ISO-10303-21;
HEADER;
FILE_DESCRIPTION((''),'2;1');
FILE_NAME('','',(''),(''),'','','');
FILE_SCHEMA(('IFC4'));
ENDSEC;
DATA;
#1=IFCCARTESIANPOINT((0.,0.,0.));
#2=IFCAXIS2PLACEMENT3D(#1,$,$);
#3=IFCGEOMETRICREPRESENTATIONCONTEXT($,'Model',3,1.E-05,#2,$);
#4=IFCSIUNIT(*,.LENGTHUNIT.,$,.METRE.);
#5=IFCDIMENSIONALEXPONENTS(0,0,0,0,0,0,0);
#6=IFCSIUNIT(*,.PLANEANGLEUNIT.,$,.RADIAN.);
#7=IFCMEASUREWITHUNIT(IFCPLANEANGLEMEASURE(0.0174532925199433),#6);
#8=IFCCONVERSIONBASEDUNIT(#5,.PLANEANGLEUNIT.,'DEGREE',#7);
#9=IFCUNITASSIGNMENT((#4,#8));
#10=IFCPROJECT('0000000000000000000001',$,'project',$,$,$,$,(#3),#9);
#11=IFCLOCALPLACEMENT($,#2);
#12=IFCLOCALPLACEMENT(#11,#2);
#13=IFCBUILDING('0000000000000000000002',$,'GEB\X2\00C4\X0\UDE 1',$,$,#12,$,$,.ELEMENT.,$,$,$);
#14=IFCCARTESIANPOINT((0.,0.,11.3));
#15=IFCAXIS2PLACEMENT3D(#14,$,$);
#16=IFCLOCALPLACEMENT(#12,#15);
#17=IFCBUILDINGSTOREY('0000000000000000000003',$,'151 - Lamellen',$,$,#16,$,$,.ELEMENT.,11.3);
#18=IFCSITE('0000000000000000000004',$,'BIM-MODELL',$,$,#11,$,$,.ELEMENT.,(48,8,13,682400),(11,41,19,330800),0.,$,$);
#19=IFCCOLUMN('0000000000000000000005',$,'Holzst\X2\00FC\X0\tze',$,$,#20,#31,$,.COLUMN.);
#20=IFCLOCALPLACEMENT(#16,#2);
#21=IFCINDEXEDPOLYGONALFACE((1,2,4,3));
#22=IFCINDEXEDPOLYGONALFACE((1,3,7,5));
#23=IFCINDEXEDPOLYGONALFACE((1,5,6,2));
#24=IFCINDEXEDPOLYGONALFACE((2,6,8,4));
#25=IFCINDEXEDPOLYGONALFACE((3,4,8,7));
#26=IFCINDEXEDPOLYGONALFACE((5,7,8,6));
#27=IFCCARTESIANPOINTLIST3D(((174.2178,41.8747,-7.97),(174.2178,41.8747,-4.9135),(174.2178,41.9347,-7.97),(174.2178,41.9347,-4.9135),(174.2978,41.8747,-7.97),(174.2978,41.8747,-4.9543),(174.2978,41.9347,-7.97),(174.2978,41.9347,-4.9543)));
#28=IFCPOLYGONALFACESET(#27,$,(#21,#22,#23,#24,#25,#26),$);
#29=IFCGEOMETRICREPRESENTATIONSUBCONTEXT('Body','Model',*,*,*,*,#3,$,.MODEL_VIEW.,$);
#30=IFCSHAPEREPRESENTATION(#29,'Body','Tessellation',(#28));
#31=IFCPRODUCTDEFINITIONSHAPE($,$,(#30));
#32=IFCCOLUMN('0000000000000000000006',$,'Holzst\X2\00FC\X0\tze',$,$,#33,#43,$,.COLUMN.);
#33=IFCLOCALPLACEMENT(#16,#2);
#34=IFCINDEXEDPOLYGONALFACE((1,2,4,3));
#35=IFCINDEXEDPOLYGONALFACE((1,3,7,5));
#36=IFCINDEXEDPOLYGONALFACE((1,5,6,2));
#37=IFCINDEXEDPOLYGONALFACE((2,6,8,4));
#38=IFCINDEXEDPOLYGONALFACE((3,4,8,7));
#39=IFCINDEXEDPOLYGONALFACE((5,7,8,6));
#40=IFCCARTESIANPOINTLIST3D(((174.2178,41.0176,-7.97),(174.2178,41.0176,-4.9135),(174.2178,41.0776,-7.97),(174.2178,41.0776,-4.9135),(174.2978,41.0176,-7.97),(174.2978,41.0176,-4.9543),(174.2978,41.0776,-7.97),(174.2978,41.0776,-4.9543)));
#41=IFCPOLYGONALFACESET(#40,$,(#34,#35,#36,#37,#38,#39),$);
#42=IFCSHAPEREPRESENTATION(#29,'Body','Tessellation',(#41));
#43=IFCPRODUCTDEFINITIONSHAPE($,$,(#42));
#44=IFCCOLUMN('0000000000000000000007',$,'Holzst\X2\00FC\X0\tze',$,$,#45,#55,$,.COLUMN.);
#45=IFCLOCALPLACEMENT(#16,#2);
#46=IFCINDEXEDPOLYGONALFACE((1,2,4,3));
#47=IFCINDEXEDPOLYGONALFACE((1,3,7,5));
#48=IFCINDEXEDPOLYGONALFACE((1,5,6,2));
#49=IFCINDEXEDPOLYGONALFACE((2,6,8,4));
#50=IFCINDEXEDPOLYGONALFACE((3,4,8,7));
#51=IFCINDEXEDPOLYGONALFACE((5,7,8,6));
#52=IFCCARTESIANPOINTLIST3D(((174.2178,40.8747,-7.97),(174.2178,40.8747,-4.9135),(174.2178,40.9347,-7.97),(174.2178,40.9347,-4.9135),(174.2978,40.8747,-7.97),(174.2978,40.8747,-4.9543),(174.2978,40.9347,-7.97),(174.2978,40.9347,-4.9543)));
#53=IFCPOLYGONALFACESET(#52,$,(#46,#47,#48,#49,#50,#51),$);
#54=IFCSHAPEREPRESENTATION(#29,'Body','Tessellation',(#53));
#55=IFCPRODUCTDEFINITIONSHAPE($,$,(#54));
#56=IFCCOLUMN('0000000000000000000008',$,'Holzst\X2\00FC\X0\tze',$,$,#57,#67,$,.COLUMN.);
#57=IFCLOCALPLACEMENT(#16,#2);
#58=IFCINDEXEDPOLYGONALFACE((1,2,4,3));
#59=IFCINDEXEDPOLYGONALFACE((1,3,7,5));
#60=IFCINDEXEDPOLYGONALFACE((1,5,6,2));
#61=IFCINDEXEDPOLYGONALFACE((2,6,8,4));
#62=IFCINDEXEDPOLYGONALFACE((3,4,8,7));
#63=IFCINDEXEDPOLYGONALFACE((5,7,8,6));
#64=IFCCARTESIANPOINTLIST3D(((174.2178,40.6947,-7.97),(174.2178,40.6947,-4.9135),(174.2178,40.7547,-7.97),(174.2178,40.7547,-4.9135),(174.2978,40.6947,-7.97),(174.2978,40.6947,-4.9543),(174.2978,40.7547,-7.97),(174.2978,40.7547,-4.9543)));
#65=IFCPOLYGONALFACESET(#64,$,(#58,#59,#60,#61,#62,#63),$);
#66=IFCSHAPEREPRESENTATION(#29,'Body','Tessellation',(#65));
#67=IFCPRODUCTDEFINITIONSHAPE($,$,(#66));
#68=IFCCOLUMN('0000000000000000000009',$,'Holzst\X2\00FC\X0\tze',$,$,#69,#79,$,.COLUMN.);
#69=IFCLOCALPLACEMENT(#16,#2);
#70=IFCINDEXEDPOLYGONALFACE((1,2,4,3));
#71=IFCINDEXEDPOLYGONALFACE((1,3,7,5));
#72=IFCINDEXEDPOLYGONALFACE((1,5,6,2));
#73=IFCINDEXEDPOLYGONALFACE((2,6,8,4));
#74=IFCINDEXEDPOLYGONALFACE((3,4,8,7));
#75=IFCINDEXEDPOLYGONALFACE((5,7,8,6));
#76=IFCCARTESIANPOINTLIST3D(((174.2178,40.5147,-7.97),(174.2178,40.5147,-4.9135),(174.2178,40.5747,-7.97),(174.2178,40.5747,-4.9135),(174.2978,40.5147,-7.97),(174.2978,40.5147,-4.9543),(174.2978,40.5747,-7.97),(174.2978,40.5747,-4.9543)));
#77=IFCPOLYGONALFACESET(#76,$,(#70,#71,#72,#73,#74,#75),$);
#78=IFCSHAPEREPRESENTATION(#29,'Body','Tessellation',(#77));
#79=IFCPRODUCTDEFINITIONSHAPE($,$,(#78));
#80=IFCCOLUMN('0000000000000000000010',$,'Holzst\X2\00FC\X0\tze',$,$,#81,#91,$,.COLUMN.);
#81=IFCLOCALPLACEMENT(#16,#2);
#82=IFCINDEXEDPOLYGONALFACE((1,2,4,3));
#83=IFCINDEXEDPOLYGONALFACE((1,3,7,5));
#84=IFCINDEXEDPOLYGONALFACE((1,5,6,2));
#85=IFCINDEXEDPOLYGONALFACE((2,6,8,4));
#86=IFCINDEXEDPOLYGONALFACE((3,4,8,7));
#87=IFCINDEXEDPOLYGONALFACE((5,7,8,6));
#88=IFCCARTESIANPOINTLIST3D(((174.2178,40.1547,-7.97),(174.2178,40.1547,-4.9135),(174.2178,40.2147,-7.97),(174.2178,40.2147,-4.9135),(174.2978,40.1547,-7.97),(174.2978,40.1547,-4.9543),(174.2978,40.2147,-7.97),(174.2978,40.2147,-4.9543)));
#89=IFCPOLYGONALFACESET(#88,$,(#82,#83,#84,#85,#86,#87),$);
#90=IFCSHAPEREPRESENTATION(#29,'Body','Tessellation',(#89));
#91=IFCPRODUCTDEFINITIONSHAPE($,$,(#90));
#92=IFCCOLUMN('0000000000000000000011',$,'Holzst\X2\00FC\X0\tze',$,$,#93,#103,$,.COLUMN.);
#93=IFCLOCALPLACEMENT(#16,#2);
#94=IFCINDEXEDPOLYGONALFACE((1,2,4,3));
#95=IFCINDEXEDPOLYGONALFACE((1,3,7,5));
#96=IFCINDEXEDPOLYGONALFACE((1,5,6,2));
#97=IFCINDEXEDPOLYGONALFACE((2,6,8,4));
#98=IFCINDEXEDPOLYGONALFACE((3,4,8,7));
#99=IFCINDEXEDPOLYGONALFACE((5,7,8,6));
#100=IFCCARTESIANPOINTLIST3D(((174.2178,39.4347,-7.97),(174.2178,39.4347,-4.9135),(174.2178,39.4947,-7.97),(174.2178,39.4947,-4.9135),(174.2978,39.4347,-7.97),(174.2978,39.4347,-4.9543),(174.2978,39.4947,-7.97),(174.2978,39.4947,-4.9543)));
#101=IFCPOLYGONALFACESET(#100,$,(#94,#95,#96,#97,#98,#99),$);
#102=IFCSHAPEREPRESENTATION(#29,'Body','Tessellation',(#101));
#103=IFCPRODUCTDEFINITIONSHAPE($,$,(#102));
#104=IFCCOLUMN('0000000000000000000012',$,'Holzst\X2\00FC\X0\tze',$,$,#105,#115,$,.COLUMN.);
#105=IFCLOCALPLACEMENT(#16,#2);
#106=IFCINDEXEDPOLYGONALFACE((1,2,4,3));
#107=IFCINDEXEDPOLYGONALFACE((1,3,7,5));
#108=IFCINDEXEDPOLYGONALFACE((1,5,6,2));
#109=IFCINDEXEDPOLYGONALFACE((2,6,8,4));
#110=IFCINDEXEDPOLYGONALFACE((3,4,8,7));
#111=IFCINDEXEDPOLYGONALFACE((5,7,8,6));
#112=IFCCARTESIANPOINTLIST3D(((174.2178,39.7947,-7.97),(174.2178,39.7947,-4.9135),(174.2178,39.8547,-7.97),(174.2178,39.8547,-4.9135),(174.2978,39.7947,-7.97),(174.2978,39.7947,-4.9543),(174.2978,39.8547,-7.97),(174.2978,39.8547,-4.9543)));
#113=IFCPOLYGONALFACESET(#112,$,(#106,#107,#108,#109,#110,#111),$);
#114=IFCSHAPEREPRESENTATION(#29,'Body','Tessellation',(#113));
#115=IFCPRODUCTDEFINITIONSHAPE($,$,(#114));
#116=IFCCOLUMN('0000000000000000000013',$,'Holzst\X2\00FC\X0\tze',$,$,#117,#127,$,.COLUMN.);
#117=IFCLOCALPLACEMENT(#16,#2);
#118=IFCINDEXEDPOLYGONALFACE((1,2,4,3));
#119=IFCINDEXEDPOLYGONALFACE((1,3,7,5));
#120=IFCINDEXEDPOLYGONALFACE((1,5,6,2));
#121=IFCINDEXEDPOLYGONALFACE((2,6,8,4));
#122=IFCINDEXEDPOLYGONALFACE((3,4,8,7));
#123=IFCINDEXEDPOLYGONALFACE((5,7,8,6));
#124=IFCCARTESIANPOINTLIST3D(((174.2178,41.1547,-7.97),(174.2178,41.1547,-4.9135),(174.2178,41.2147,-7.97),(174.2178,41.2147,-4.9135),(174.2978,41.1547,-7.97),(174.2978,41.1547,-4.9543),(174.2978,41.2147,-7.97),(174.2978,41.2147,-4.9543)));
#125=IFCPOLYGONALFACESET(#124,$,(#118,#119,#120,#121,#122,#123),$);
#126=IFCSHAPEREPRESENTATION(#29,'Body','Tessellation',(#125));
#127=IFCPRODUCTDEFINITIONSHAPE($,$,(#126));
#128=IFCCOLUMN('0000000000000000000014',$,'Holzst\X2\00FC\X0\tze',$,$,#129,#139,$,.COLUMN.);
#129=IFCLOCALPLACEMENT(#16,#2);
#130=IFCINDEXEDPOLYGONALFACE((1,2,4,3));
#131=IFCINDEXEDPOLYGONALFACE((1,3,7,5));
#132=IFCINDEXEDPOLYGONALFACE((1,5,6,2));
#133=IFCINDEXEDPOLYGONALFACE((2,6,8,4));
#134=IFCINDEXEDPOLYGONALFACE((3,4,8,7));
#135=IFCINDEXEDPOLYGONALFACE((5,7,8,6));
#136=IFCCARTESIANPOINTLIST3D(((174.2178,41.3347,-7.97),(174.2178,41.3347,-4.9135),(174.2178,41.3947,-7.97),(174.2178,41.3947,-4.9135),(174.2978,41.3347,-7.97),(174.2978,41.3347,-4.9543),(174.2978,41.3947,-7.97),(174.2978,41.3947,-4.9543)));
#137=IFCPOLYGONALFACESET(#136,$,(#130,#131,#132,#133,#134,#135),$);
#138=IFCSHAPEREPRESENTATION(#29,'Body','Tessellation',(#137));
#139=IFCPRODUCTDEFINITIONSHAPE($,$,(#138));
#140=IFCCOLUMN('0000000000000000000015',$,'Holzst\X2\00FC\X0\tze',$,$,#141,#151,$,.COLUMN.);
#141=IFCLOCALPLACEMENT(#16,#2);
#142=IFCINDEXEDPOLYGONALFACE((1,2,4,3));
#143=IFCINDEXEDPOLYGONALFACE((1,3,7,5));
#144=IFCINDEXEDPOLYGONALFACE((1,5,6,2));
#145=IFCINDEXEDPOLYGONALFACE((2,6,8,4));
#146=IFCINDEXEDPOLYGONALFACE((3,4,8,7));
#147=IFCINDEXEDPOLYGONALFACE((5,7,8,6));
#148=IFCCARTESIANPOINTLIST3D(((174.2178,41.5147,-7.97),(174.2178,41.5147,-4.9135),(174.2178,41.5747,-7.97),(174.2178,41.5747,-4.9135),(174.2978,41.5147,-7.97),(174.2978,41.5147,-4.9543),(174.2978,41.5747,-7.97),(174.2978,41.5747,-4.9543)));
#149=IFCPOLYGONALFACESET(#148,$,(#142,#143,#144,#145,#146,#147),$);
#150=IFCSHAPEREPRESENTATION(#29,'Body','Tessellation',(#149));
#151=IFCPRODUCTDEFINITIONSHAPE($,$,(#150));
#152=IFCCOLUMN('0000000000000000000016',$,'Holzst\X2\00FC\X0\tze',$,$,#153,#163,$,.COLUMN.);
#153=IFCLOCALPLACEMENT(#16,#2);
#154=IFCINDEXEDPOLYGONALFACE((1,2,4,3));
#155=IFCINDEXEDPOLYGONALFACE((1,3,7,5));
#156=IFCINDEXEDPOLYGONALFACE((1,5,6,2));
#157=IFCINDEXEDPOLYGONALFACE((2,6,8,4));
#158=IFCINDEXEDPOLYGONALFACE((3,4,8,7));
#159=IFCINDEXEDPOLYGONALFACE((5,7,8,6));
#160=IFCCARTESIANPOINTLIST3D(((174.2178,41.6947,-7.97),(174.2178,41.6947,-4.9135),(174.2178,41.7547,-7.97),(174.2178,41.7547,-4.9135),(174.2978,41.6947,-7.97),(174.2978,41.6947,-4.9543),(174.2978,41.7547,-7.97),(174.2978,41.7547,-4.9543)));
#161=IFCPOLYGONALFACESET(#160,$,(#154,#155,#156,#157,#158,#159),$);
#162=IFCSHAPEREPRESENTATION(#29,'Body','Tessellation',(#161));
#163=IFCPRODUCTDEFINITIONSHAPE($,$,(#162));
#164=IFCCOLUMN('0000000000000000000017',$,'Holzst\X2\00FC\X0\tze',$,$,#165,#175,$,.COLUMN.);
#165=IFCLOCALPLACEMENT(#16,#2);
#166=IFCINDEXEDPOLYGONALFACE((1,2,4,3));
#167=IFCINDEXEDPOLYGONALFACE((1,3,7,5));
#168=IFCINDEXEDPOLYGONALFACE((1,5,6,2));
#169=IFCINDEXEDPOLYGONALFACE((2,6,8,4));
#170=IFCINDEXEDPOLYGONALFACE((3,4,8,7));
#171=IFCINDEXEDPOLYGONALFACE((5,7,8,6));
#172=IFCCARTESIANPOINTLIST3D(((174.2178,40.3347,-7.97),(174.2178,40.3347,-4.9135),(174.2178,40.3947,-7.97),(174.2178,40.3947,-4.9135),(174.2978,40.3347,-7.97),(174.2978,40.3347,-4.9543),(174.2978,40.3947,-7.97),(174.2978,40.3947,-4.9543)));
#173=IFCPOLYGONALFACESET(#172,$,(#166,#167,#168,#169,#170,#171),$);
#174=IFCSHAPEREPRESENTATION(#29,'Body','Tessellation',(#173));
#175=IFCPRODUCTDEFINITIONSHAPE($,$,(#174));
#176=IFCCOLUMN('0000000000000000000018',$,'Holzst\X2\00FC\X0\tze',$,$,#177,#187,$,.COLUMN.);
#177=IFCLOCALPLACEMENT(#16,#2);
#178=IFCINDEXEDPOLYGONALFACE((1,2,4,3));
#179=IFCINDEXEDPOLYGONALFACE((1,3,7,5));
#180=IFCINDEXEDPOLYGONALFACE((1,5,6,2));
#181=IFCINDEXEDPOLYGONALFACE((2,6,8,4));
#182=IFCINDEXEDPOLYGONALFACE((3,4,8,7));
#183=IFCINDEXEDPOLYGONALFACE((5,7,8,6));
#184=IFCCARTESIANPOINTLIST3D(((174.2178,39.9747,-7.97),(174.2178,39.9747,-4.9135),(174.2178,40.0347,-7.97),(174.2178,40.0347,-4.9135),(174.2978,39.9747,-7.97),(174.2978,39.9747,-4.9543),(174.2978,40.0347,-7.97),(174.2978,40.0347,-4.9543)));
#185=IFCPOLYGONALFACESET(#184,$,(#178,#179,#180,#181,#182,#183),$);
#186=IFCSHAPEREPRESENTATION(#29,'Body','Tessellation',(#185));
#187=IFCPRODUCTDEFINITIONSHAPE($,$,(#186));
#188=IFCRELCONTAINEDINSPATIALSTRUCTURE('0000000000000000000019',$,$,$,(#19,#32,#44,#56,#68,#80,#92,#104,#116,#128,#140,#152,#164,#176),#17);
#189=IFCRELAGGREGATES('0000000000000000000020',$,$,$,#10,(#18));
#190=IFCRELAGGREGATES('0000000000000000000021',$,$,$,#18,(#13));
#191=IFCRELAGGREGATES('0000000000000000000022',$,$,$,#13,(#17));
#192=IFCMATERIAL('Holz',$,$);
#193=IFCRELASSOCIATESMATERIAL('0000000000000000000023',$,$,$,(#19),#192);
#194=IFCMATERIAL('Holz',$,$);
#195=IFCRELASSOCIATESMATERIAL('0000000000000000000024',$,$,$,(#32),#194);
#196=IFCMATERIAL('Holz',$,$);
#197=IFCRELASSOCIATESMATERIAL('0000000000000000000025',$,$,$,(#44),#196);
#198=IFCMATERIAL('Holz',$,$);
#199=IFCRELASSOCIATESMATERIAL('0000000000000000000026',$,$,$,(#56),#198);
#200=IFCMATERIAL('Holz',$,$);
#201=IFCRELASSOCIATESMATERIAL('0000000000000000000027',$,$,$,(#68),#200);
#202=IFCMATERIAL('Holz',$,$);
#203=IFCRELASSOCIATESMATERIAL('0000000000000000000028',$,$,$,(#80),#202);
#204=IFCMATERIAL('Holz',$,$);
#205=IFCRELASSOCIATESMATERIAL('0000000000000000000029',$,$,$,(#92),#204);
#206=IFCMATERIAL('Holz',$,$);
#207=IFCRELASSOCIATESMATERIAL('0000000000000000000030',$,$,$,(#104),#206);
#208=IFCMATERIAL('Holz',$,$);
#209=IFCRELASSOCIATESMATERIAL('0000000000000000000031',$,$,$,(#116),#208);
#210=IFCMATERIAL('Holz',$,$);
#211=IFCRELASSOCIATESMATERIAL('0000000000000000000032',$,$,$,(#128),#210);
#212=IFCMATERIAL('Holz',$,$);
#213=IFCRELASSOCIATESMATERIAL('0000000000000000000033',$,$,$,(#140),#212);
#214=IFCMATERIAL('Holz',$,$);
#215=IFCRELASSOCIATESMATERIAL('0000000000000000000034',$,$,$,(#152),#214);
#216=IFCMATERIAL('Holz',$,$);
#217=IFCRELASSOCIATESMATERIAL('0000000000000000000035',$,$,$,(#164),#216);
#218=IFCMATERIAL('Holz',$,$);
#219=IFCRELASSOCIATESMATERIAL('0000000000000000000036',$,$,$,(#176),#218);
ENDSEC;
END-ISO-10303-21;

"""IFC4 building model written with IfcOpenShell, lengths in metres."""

from ifc_helpers import new_model, entity, si_unit, converted_unit, frame, frame_2d, origin, origin_with_axes, place, context, subcontext, project, spatial, rectangle, extrude, clip, halfspace, material, element, save


model = new_model("IFC4")

# Units and contexts
model_context = context("Model", 3, precision=1e-05, world=origin())
body_context = subcontext(model_context, "Body", "Model", "MODEL_VIEW")
ifc_project = project(units=[si_unit("LENGTHUNIT", "METRE"), converted_unit("PLANEANGLEUNIT", "DEGREE", entity("IfcPlaneAngleMeasure", 0.0174532925199433), si_unit("PLANEANGLEUNIT", "RADIAN"), dimensions=[0, 0, 0, 0, 0, 0, 0])], contexts=[model_context])

# Site, building, storey
site_placement = place(None, origin())
site = spatial("IfcSite", under=ifc_project, at=site_placement, Name="BIM-MODELL", CompositionType="ELEMENT", RefLatitude=(48, 8, 13, 682400), RefLongitude=(11, 41, 19, 330800), RefElevation=0.0)
building_placement = place(site_placement, origin())
building = spatial("IfcBuilding", under=site, at=building_placement, Name="GEBÄUDE 1", CompositionType="ELEMENT")
storey_placement = place(building_placement, frame((0.0, 0.0, 11.3)))
storey = spatial("IfcBuildingStorey", under=building, at=storey_placement, Name="151 - Lamellen", CompositionType="ELEMENT", Elevation=11.3)

# Columns
ifc_material_1 = material(Name="Holz")
column_1_placement = place(storey_placement, frame((174.2978, 41.8747, -7.97)))
element("IfcColumn", 1, at=column_1_placement, inside=storey, material=ifc_material_1, Name="Holzstütze", PredefinedType="COLUMN", context=body_context, shape_type="Clipping", body=[
    clip(extrude(rectangle(XDim=0.06, YDim=0.08, at=frame_2d((-0.04, 0.03), x_axis=(0.0, 1.0))), origin_with_axes(), (0.0, 0.0, 1.0), 3.0565), halfspace(frame((-0.04, 0.03, 3.0361), z_axis=(-0.45399, 0.0, -0.891007), x_axis=(0.891007, 0.0, -0.45399)), True)),
])
ifc_material_2 = material(Name="Holz")
column_2_placement = place(storey_placement, frame((174.2978, 41.0176, -7.97)))
element("IfcColumn", 2, at=column_2_placement, inside=storey, material=ifc_material_2, Name="Holzstütze", PredefinedType="COLUMN", context=body_context, shape_type="Clipping", body=[
    clip(extrude(rectangle(XDim=0.06, YDim=0.08, at=frame_2d((-0.04, 0.03), x_axis=(0.0, 1.0))), origin_with_axes(), (0.0, 0.0, 1.0), 3.0565), halfspace(frame((-0.04, 0.03, 3.0361), z_axis=(-0.45399, 0.0, -0.891007), x_axis=(0.891007, 0.0, -0.45399)), True)),
])
ifc_material_3 = material(Name="Holz")
column_3_placement = place(storey_placement, frame((174.2978, 40.8747, -7.97)))
element("IfcColumn", 3, at=column_3_placement, inside=storey, material=ifc_material_3, Name="Holzstütze", PredefinedType="COLUMN", context=body_context, shape_type="Clipping", body=[
    clip(extrude(rectangle(XDim=0.06, YDim=0.08, at=frame_2d((-0.04, 0.03), x_axis=(0.0, 1.0))), origin_with_axes(), (0.0, 0.0, 1.0), 3.0565), halfspace(frame((-0.04, 0.03, 3.0361), z_axis=(-0.45399, 0.0, -0.891007), x_axis=(0.891007, 0.0, -0.45399)), True)),
])
ifc_material_4 = material(Name="Holz")
column_4_placement = place(storey_placement, frame((174.2978, 40.6947, -7.97)))
element("IfcColumn", 4, at=column_4_placement, inside=storey, material=ifc_material_4, Name="Holzstütze", PredefinedType="COLUMN", context=body_context, shape_type="Clipping", body=[
    clip(extrude(rectangle(XDim=0.06, YDim=0.08, at=frame_2d((-0.04, 0.03), x_axis=(0.0, 1.0))), origin_with_axes(), (0.0, 0.0, 1.0), 3.0565), halfspace(frame((-0.04, 0.03, 3.0361), z_axis=(-0.45399, 0.0, -0.891007), x_axis=(0.891007, 0.0, -0.45399)), True)),
])
ifc_material_5 = material(Name="Holz")
column_5_placement = place(storey_placement, frame((174.2978, 40.5147, -7.97)))
element("IfcColumn", 5, at=column_5_placement, inside=storey, material=ifc_material_5, Name="Holzstütze", PredefinedType="COLUMN", context=body_context, shape_type="Clipping", body=[
    clip(extrude(rectangle(XDim=0.06, YDim=0.08, at=frame_2d((-0.04, 0.03), x_axis=(0.0, 1.0))), origin_with_axes(), (0.0, 0.0, 1.0), 3.0565), halfspace(frame((-0.04, 0.03, 3.0361), z_axis=(-0.45399, 0.0, -0.891007), x_axis=(0.891007, 0.0, -0.45399)), True)),
])
ifc_material_6 = material(Name="Holz")
column_6_placement = place(storey_placement, frame((174.2978, 40.1547, -7.97)))
element("IfcColumn", 6, at=column_6_placement, inside=storey, material=ifc_material_6, Name="Holzstütze", PredefinedType="COLUMN", context=body_context, shape_type="Clipping", body=[
    clip(extrude(rectangle(XDim=0.06, YDim=0.08, at=frame_2d((-0.04, 0.03), x_axis=(0.0, 1.0))), origin_with_axes(), (0.0, 0.0, 1.0), 3.0565), halfspace(frame((-0.04, 0.03, 3.0361), z_axis=(-0.45399, 0.0, -0.891007), x_axis=(0.891007, 0.0, -0.45399)), True)),
])
ifc_material_7 = material(Name="Holz")
column_7_placement = place(storey_placement, frame((174.2978, 39.4347, -7.97)))
element("IfcColumn", 7, at=column_7_placement, inside=storey, material=ifc_material_7, Name="Holzstütze", PredefinedType="COLUMN", context=body_context, shape_type="Clipping", body=[
    clip(extrude(rectangle(XDim=0.06, YDim=0.08, at=frame_2d((-0.04, 0.03), x_axis=(0.0, 1.0))), origin_with_axes(), (0.0, 0.0, 1.0), 3.0565), halfspace(frame((-0.04, 0.03, 3.0361), z_axis=(-0.45399, 0.0, -0.891007), x_axis=(0.891007, 0.0, -0.45399)), True)),
])
ifc_material_8 = material(Name="Holz")
column_8_placement = place(storey_placement, frame((174.2978, 39.7947, -7.97)))
element("IfcColumn", 8, at=column_8_placement, inside=storey, material=ifc_material_8, Name="Holzstütze", PredefinedType="COLUMN", context=body_context, shape_type="Clipping", body=[
    clip(extrude(rectangle(XDim=0.06, YDim=0.08, at=frame_2d((-0.04, 0.03), x_axis=(0.0, 1.0))), origin_with_axes(), (0.0, 0.0, 1.0), 3.0565), halfspace(frame((-0.04, 0.03, 3.0361), z_axis=(-0.45399, 0.0, -0.891007), x_axis=(0.891007, 0.0, -0.45399)), True)),
])
ifc_material_9 = material(Name="Holz")
column_9_placement = place(storey_placement, frame((174.2978, 41.1547, -7.97)))
element("IfcColumn", 9, at=column_9_placement, inside=storey, material=ifc_material_9, Name="Holzstütze", PredefinedType="COLUMN", context=body_context, shape_type="Clipping", body=[
    clip(extrude(rectangle(XDim=0.06, YDim=0.08, at=frame_2d((-0.04, 0.03), x_axis=(0.0, 1.0))), origin_with_axes(), (0.0, 0.0, 1.0), 3.0565), halfspace(frame((-0.04, 0.03, 3.0361), z_axis=(-0.45399, 0.0, -0.891007), x_axis=(0.891007, 0.0, -0.45399)), True)),
])
ifc_material_10 = material(Name="Holz")
column_10_placement = place(storey_placement, frame((174.2978, 41.3347, -7.97)))
element("IfcColumn", 10, at=column_10_placement, inside=storey, material=ifc_material_10, Name="Holzstütze", PredefinedType="COLUMN", context=body_context, shape_type="Clipping", body=[
    clip(extrude(rectangle(XDim=0.06, YDim=0.08, at=frame_2d((-0.04, 0.03), x_axis=(0.0, 1.0))), origin_with_axes(), (0.0, 0.0, 1.0), 3.0565), halfspace(frame((-0.04, 0.03, 3.0361), z_axis=(-0.45399, 0.0, -0.891007), x_axis=(0.891007, 0.0, -0.45399)), True)),
])
ifc_material_11 = material(Name="Holz")
column_11_placement = place(storey_placement, frame((174.2978, 41.5147, -7.97)))
element("IfcColumn", 11, at=column_11_placement, inside=storey, material=ifc_material_11, Name="Holzstütze", PredefinedType="COLUMN", context=body_context, shape_type="Clipping", body=[
    clip(extrude(rectangle(XDim=0.06, YDim=0.08, at=frame_2d((-0.04, 0.03), x_axis=(0.0, 1.0))), origin_with_axes(), (0.0, 0.0, 1.0), 3.0565), halfspace(frame((-0.04, 0.03, 3.0361), z_axis=(-0.45399, 0.0, -0.891007), x_axis=(0.891007, 0.0, -0.45399)), True)),
])
ifc_material_12 = material(Name="Holz")
column_12_placement = place(storey_placement, frame((174.2978, 41.6947, -7.97)))
element("IfcColumn", 12, at=column_12_placement, inside=storey, material=ifc_material_12, Name="Holzstütze", PredefinedType="COLUMN", context=body_context, shape_type="Clipping", body=[
    clip(extrude(rectangle(XDim=0.06, YDim=0.08, at=frame_2d((-0.04, 0.03), x_axis=(0.0, 1.0))), origin_with_axes(), (0.0, 0.0, 1.0), 3.0565), halfspace(frame((-0.04, 0.03, 3.0361), z_axis=(-0.45399, 0.0, -0.891007), x_axis=(0.891007, 0.0, -0.45399)), True)),
])
ifc_material_13 = material(Name="Holz")
column_13_placement = place(storey_placement, frame((174.2978, 40.3347, -7.97)))
element("IfcColumn", 13, at=column_13_placement, inside=storey, material=ifc_material_13, Name="Holzstütze", PredefinedType="COLUMN", context=body_context, shape_type="Clipping", body=[
    clip(extrude(rectangle(XDim=0.06, YDim=0.08, at=frame_2d((-0.04, 0.03), x_axis=(0.0, 1.0))), origin_with_axes(), (0.0, 0.0, 1.0), 3.0565), halfspace(frame((-0.04, 0.03, 3.0361), z_axis=(-0.45399, 0.0, -0.891007), x_axis=(0.891007, 0.0, -0.45399)), True)),
])
ifc_material_14 = material(Name="Holz")
column_14_placement = place(storey_placement, frame((174.2978, 39.9747, -7.97)))
element("IfcColumn", 14, at=column_14_placement, inside=storey, material=ifc_material_14, Name="Holzstütze", PredefinedType="COLUMN", context=body_context, shape_type="Clipping", body=[
    clip(extrude(rectangle(XDim=0.06, YDim=0.08, at=frame_2d((-0.04, 0.03), x_axis=(0.0, 1.0))), origin_with_axes(), (0.0, 0.0, 1.0), 3.0565), halfspace(frame((-0.04, 0.03, 3.0361), z_axis=(-0.45399, 0.0, -0.891007), x_axis=(0.891007, 0.0, -0.45399)), True)),
])

save(model, "model.ifc")
